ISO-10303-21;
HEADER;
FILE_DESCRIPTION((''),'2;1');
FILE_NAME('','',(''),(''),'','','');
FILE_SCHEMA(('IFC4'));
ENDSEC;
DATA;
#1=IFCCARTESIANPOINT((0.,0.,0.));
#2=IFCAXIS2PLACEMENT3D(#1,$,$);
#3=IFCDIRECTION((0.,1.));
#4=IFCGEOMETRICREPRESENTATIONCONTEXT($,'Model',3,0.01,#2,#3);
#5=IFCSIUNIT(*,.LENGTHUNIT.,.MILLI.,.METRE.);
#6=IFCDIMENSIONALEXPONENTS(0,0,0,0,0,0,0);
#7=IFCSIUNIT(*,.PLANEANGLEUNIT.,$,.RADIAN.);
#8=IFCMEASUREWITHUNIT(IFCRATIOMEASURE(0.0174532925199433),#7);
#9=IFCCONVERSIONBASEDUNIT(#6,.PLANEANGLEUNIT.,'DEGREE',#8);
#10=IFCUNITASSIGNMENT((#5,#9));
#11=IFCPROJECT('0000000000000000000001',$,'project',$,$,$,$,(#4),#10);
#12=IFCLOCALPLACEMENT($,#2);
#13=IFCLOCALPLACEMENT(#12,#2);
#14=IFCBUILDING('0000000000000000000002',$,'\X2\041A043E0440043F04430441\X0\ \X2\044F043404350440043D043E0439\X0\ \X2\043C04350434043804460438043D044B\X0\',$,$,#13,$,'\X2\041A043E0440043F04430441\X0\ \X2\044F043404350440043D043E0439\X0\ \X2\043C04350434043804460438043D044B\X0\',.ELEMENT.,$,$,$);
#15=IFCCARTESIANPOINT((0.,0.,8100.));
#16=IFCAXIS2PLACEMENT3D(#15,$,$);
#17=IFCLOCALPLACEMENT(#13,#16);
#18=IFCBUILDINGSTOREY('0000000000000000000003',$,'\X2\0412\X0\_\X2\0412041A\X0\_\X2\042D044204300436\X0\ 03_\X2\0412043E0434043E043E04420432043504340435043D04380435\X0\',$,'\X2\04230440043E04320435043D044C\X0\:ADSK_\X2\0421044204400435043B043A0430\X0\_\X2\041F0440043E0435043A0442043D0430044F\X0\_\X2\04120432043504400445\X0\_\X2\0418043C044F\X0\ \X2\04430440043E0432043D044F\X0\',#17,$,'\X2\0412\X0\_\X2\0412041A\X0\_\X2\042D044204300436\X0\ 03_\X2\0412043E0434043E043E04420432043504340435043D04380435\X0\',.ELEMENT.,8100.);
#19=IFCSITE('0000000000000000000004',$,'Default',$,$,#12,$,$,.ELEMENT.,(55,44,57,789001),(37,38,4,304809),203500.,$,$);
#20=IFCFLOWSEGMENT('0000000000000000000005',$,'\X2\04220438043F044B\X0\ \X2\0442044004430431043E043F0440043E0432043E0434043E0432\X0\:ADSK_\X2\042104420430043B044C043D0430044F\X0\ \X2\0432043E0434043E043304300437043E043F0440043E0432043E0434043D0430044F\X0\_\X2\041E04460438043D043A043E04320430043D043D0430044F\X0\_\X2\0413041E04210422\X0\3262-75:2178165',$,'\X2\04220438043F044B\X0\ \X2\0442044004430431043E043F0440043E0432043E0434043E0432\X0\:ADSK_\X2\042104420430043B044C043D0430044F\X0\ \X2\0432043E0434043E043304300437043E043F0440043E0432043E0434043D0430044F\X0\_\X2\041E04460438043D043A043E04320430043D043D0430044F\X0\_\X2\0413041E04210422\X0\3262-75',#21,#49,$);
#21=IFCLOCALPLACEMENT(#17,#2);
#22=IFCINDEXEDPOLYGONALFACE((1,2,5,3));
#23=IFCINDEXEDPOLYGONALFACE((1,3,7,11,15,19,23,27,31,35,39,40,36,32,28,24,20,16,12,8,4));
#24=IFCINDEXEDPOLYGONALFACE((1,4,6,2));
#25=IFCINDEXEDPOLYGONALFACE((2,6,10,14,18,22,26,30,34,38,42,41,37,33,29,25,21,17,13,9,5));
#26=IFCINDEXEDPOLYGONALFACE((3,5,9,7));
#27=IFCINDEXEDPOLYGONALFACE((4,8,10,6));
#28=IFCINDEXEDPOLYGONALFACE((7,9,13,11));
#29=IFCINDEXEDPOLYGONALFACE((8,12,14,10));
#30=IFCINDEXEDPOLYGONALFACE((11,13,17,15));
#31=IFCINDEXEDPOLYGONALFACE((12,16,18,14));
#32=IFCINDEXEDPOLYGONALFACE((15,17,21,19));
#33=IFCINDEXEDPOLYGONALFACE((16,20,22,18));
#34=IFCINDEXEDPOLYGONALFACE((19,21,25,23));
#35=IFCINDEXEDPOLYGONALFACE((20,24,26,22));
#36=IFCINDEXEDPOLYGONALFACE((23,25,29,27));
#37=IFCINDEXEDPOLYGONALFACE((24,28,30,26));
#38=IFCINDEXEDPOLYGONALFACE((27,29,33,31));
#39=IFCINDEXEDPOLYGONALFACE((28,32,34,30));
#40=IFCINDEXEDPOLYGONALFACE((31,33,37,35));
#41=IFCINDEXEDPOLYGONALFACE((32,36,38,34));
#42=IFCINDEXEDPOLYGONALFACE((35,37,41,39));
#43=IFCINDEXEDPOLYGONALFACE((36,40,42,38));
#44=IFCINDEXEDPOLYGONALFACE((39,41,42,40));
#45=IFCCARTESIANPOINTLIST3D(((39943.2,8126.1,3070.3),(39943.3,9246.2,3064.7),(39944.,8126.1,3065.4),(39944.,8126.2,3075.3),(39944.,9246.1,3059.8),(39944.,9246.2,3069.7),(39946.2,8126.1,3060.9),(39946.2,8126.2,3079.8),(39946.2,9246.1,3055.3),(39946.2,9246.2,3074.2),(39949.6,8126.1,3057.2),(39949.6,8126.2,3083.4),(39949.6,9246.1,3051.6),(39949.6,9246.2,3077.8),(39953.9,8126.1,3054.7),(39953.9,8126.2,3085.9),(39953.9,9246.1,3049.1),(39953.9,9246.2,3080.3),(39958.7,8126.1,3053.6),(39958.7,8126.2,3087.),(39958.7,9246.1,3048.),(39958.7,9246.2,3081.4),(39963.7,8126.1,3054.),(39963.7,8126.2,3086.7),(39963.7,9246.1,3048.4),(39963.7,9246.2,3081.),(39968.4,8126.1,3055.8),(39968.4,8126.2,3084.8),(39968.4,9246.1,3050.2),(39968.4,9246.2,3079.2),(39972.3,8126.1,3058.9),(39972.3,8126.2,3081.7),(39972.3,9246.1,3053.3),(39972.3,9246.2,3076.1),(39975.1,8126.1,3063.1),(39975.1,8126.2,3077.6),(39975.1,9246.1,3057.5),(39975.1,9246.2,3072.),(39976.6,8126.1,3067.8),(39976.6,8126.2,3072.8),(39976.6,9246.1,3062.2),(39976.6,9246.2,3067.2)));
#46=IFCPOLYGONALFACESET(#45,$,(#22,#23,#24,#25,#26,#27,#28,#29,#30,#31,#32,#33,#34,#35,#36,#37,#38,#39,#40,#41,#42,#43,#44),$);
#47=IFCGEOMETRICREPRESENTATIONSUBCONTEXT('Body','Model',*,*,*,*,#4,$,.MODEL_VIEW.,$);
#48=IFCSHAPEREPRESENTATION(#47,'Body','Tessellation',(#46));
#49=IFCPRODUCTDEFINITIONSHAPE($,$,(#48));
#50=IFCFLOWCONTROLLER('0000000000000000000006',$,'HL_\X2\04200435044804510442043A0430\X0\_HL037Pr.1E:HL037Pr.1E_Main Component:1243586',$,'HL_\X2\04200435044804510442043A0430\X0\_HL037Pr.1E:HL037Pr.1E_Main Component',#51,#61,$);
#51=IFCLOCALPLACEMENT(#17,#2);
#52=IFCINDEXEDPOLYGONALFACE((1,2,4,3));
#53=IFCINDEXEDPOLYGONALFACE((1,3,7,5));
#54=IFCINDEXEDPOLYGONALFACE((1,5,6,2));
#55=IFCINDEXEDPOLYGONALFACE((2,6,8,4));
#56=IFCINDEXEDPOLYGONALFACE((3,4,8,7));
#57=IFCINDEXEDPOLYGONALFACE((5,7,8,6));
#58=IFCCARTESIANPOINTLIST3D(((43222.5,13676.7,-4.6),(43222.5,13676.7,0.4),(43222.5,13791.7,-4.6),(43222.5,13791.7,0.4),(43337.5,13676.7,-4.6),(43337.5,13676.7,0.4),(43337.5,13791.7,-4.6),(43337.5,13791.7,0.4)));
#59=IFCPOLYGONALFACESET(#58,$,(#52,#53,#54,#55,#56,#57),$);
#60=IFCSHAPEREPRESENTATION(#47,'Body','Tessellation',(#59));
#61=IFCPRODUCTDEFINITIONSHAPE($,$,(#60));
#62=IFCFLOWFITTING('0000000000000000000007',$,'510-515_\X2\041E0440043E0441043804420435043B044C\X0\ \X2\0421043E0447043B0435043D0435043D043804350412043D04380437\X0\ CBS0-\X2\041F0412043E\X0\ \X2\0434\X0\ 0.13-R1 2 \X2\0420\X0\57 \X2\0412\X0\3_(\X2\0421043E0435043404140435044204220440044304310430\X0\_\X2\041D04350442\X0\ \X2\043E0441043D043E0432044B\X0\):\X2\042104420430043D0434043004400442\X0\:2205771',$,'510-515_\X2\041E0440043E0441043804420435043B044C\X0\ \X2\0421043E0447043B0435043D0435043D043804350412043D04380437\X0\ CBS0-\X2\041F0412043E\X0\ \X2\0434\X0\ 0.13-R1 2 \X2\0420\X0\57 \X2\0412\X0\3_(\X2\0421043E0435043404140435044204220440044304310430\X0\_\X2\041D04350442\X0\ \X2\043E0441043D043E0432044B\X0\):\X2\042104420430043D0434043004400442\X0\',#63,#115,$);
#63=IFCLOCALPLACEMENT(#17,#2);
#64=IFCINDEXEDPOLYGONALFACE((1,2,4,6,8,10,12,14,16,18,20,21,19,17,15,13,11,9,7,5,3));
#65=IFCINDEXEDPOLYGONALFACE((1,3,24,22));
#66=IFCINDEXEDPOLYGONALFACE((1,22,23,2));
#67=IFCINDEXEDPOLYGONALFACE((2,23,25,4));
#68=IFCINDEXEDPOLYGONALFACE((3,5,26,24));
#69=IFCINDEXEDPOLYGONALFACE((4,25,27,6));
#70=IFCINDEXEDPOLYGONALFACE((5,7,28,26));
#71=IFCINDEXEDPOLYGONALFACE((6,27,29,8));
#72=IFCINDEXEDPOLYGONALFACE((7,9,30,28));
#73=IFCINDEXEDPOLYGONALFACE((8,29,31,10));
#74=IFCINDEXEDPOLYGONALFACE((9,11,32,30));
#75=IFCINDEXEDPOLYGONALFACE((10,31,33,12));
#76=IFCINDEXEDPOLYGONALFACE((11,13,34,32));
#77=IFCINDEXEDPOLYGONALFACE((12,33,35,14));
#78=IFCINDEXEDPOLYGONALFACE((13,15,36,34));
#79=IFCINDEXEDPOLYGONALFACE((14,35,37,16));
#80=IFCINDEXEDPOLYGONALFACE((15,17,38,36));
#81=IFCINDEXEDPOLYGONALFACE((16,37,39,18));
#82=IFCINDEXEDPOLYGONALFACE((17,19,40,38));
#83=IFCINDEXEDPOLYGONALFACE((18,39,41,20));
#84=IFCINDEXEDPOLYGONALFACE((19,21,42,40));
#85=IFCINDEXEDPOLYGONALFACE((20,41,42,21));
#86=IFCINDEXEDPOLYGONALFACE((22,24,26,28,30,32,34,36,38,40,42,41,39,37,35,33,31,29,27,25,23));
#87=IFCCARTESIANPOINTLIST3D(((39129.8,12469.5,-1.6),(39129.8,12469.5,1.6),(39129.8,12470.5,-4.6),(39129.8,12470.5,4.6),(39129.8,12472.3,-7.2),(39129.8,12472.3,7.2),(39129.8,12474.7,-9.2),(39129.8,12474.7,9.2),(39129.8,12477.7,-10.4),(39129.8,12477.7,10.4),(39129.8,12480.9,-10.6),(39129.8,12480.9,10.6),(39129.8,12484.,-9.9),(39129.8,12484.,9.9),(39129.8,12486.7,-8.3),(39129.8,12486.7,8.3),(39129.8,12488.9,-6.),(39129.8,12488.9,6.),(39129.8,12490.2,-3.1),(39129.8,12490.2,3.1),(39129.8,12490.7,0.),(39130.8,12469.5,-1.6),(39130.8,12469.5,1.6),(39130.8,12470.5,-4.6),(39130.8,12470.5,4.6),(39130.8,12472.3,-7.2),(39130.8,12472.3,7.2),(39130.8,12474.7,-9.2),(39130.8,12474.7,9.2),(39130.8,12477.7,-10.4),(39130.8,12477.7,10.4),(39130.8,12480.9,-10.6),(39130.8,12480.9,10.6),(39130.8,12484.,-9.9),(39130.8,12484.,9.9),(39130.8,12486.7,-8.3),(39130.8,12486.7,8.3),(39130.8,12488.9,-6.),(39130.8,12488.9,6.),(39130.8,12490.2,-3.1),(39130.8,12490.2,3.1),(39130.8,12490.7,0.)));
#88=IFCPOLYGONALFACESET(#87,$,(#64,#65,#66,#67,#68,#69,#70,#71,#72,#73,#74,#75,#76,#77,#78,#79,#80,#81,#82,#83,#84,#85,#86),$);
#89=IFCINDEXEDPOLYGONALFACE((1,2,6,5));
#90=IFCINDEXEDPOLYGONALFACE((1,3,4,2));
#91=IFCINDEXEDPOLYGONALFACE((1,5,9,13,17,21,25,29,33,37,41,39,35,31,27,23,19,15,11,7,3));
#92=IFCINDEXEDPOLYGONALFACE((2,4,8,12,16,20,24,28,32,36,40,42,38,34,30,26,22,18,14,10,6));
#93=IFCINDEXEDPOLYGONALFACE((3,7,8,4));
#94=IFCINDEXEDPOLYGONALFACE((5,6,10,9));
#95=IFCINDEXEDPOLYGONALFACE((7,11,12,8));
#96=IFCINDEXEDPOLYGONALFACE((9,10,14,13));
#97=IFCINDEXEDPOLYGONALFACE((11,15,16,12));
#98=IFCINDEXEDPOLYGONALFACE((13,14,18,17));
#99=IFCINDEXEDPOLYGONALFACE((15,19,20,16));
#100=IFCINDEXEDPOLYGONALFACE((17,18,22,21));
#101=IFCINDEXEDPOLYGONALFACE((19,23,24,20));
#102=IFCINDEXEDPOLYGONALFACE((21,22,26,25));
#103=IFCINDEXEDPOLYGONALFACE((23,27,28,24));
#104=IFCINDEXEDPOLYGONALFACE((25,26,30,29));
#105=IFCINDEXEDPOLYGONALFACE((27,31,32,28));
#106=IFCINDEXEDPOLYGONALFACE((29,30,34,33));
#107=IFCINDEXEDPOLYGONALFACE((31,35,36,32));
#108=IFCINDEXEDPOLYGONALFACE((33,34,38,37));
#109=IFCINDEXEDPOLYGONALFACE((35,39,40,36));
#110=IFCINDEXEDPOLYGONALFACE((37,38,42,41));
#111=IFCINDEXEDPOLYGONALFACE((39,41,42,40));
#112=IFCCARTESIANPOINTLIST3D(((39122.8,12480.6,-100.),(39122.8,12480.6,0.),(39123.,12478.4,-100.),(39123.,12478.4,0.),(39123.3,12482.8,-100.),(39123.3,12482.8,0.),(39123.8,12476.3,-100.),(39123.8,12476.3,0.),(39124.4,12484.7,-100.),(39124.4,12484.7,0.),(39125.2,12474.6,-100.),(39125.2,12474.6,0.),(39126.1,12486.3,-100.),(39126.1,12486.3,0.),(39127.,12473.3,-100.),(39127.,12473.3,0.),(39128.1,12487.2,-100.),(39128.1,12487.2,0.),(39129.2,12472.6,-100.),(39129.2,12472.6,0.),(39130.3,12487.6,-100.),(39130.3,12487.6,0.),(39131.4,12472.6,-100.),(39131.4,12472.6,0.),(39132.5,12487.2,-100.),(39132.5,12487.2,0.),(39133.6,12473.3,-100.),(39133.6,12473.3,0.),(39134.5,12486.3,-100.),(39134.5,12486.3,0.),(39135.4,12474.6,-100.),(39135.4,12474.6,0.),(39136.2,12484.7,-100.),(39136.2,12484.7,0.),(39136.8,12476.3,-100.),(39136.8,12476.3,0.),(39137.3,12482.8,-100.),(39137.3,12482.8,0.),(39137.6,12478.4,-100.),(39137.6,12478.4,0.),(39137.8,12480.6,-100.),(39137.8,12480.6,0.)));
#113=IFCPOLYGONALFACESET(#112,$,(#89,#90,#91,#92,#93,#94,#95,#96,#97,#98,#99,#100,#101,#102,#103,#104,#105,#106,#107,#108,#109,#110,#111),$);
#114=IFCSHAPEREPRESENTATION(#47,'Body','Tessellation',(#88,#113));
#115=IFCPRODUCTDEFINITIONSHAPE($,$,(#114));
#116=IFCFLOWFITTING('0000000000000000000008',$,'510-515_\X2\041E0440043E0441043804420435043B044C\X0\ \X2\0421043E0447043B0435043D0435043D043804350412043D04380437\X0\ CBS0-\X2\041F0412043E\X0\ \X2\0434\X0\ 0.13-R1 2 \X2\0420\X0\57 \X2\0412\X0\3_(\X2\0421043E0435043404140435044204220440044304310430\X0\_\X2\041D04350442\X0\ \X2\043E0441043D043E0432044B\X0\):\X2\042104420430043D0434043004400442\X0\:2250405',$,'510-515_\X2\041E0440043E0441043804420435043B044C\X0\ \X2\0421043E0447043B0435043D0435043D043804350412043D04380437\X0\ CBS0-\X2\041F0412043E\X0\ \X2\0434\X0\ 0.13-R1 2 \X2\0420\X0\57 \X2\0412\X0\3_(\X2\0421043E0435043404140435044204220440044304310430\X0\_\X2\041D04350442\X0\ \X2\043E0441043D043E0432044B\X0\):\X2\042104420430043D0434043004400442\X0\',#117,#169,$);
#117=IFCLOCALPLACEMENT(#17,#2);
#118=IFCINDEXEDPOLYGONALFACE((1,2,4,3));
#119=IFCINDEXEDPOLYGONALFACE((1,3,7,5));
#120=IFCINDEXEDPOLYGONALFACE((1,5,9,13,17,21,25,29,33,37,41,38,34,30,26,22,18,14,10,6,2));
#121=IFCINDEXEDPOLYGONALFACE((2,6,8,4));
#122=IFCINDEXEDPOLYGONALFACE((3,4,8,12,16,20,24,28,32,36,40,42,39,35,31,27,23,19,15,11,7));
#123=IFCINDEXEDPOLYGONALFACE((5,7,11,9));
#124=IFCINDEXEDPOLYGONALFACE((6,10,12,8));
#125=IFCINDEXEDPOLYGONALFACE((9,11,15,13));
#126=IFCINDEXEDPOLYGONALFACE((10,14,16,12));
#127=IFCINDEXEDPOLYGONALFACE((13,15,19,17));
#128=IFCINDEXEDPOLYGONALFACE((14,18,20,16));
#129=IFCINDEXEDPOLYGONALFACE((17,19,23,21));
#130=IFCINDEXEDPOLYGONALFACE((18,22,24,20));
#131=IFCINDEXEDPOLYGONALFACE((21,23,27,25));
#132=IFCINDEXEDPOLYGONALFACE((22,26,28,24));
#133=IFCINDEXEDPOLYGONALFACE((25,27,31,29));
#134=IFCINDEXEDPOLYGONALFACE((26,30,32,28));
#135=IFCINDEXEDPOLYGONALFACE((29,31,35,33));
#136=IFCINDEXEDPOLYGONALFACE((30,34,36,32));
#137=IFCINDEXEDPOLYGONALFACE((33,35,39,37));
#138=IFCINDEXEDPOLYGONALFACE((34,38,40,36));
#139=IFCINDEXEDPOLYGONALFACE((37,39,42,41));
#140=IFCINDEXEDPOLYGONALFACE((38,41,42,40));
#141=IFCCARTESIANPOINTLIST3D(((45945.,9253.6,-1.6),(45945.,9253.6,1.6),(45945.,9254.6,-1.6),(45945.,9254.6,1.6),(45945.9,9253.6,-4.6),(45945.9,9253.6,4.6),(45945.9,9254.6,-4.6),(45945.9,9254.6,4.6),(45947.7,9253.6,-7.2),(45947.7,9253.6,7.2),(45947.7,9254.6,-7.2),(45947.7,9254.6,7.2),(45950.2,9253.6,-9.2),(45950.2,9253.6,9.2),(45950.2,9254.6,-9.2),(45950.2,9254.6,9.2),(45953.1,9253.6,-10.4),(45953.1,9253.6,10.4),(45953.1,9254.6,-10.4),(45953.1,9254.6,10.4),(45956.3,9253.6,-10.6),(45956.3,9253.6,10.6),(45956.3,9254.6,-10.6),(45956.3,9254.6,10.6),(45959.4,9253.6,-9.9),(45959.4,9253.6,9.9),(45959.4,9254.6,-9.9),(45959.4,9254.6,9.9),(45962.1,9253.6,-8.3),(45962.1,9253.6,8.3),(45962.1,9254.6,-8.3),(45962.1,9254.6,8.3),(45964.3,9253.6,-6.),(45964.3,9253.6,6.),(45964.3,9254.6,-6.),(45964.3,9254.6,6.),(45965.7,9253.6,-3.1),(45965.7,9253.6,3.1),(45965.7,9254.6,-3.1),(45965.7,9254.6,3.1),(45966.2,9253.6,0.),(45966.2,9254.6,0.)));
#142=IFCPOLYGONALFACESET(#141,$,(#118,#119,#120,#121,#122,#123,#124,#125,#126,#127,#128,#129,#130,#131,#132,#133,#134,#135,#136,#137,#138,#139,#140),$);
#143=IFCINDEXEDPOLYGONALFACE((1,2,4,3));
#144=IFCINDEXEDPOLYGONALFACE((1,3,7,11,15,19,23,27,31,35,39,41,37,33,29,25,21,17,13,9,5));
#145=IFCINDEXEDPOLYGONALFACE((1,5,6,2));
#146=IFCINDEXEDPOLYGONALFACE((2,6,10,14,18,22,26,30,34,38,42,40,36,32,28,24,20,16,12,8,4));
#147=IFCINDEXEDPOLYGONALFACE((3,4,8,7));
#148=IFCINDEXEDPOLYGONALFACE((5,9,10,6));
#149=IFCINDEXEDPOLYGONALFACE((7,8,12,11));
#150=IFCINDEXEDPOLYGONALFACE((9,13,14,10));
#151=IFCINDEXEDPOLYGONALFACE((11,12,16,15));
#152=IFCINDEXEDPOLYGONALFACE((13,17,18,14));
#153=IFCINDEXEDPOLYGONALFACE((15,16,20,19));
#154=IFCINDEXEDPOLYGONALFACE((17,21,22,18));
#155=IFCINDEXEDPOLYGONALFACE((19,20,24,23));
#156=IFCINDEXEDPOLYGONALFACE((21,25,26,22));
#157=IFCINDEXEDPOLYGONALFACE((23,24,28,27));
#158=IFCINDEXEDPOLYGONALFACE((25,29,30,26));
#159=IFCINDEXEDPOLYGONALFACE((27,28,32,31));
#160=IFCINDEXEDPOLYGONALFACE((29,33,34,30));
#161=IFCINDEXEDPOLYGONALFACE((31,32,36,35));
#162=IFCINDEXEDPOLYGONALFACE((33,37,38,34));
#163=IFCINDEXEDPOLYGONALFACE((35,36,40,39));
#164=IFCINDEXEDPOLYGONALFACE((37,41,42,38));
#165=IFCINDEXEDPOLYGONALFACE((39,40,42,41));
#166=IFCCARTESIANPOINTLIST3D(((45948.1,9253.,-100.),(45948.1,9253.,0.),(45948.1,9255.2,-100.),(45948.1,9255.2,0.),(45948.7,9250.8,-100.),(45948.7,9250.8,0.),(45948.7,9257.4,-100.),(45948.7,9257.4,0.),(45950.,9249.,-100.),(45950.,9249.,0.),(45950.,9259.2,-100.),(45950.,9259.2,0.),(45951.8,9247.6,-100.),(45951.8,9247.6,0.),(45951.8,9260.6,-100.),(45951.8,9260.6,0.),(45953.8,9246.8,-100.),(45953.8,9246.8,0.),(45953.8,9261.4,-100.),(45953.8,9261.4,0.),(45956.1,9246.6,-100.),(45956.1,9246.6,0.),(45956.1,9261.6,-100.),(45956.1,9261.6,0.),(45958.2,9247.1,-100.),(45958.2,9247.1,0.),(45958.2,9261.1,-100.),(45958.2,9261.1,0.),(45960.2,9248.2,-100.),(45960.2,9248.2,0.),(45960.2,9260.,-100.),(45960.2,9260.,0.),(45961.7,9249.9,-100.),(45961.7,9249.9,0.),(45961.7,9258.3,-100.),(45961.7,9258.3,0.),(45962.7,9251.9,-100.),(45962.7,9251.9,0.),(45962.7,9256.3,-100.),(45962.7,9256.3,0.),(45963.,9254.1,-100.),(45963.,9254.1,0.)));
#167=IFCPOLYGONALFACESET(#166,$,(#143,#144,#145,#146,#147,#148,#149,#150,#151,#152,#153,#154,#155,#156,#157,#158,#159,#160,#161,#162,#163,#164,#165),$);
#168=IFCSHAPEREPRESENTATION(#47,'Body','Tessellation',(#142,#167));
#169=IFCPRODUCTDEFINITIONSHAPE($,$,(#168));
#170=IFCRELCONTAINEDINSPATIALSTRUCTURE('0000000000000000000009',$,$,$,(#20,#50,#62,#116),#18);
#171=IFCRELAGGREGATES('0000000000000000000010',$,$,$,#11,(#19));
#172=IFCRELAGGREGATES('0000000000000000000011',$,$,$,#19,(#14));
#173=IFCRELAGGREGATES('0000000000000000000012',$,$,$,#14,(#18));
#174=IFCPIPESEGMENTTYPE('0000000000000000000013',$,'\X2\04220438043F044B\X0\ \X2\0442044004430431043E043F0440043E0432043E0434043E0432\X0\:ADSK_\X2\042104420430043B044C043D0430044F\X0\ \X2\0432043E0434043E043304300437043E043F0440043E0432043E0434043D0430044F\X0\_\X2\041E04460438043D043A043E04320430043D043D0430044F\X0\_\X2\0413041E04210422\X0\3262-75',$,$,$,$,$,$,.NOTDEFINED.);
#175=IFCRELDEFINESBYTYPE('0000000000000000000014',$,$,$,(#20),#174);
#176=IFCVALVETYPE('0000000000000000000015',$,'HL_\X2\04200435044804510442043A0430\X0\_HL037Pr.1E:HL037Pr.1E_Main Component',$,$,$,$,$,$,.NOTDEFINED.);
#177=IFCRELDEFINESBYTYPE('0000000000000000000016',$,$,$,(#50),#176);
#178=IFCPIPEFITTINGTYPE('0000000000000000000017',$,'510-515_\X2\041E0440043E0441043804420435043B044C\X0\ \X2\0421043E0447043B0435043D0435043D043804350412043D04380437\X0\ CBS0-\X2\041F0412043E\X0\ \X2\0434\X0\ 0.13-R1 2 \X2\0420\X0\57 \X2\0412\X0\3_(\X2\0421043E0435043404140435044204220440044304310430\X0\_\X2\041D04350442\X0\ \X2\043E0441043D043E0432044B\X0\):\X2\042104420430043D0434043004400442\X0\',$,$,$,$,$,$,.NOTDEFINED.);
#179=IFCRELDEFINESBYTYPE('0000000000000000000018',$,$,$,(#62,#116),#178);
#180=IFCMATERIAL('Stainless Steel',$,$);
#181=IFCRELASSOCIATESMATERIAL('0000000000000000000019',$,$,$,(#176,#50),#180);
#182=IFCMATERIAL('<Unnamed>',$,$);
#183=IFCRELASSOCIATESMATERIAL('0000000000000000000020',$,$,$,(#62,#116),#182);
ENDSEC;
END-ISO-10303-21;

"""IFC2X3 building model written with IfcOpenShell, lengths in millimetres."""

from ifc_helpers import new_model, entity, si_unit, converted_unit, direction, frame, origin, origin_2d_with_axis, place, context, subcontext, project, spatial, rectangle, circle, extrude, source, transform, mapped, material, type_object, type_shapes, element, save


model = new_model("IFC2X3")

# Units and contexts
model_context = context("Model", 3, precision=0.01, world=origin(), true_north=direction((0.0, 1.0)))
body_context = subcontext(model_context, "Body", "Model", "MODEL_VIEW")
ifc_project = project(units=[si_unit("LENGTHUNIT", "METRE", prefix="MILLI"), converted_unit("PLANEANGLEUNIT", "DEGREE", entity("IfcRatioMeasure", 0.0174532925199433), si_unit("PLANEANGLEUNIT", "RADIAN"), dimensions=[0, 0, 0, 0, 0, 0, 0])], contexts=[model_context])

# Site, building, storey
site_placement = place(None, origin())
site = spatial("IfcSite", under=ifc_project, at=site_placement, Name="Default", CompositionType="ELEMENT", RefLatitude=(55, 44, 57, 789001), RefLongitude=(37, 38, 4, 304809), RefElevation=203500.0)
building_placement = place(site_placement, origin())
building = spatial("IfcBuilding", under=site, at=building_placement, Name="Корпус ядерной медицины", LongName="Корпус ядерной медицины", CompositionType="ELEMENT")
storey_placement = place(building_placement, frame((0.0, 0.0, 8100.0)))
storey = spatial("IfcBuildingStorey", under=building, at=storey_placement, Name="В_ВК_Этаж 03_Водоотведение", ObjectType="Уровень:ADSK_Стрелка_Проектная_Вверх_Имя уровня", LongName="В_ВК_Этаж 03_Водоотведение", CompositionType="ELEMENT", Elevation=8100.0)

# Flow segment
pipe_segment_type_1 = type_object("IfcPipeSegmentType", Name="Типы трубопроводов:ADSK_Стальная водогазопроводная_Оцинкованная_ГОСТ3262-75", PredefinedType="NOTDEFINED")
for number, where, name in (
    (1, (39941.7, 8126.1, 3046.4), "Типы трубопроводов:ADSK_Стальная водогазопроводная_Оцинкованная_ГОСТ3262-75:2178165"),
):
    element("IfcFlowSegment", number, at=place(storey_placement, frame(where)), inside=storey, type_object=pipe_segment_type_1, Name=name, ObjectType="Типы трубопроводов:ADSK_Стальная водогазопроводная_Оцинкованная_ГОСТ3262-75", context=body_context, shape_type="SweptSolid", body=[
        extrude(circle(Radius=16.8, at=origin_2d_with_axis()), frame((18.4, 1120.1, 18.4), z_axis=(-0.000001, -0.999987, 0.005), x_axis=(-1.0, 0.000001, 0.0)), (0.0, 0.0, 1.0), 1120.0),
    ])

# Flow controller
ifc_material_1 = material(Name="Stainless Steel")
valve_type = type_object("IfcValveType", Name="HL_Решётка_HL037Pr.1E:HL037Pr.1E_Main Component", PredefinedType="NOTDEFINED", material=ifc_material_1)
shared_shape_1 = source(origin(), body_context, "Body", "SweptSolid", [
    extrude(rectangle(XDim=115.0, YDim=115.0, at=origin_2d_with_axis()), frame((0.0, 0.0, -5.0), z_axis=(0.0, 0.0, 1.0), x_axis=(0.0, -1.0, 0.0)), (0.0, 0.0, 1.0), 5.0),
])
type_shapes(valve_type, [shared_shape_1])
flow_controller_placement = place(storey_placement, frame((43280.0, 13734.2, 0.4)))
element("IfcFlowController", 2, at=flow_controller_placement, inside=storey, type_object=valve_type, material=ifc_material_1, Name="HL_Решётка_HL037Pr.1E:HL037Pr.1E_Main Component:1243586", ObjectType="HL_Решётка_HL037Pr.1E:HL037Pr.1E_Main Component", context=body_context, shape_type="MappedRepresentation", body=[
    mapped(shared_shape_1, transform((0.0, 0.0, 0.0), scale=1.0)),
])

# Flow fittings
ifc_material_2 = material(Name="<Unnamed>")
pipe_fitting_type = type_object("IfcPipeFittingType", Name="510-515_Ороситель СочленениеВниз CBS0-ПВо д 0.13-R1 2 Р57 В3_(СоедДетТруба_Нет основы):Стандарт", PredefinedType="NOTDEFINED")
shared_shape_2 = source(origin(), body_context, "Body", "SweptSolid", [
    extrude(circle(Radius=10.7, at=origin_2d_with_axis()), frame((-0.5, 0.0, 0.0), z_axis=(1.0, 0.0, 0.0), x_axis=(0.0, 1.0, 0.0)), (0.0, 0.0, 1.0), 1.0),
    extrude(circle(Radius=7.5, at=origin_2d_with_axis()), frame((0.0, 0.0, -100.0), z_axis=(0.0, 0.0, 1.0), x_axis=(0.0, 1.0, 0.0)), (0.0, 0.0, 1.0), 100.0),
])
type_shapes(pipe_fitting_type, [shared_shape_2])
flow_fitting_placement = place(storey_placement, frame((39130.3, 12480.1, 0.0)))
element("IfcFlowFitting", 3, at=flow_fitting_placement, inside=storey, type_object=pipe_fitting_type, material=ifc_material_2, Name="510-515_Ороситель СочленениеВниз CBS0-ПВо д 0.13-R1 2 Р57 В3_(СоедДетТруба_Нет основы):Стандарт:2205771", ObjectType="510-515_Ороситель СочленениеВниз CBS0-ПВо д 0.13-R1 2 Р57 В3_(СоедДетТруба_Нет основы):Стандарт", context=body_context, shape_type="MappedRepresentation", body=[
    mapped(shared_shape_2, transform((0.0, 0.0, 0.0), scale=1.0)),
])
for number, where, z_axis, x_axis, name in (
    (4, (45955.5, 9254.1, 0.0), (0.0, 0.0, 1.0), (0.0, -1.0, 0.0), "510-515_Ороситель СочленениеВниз CBS0-ПВо д 0.13-R1 2 Р57 В3_(СоедДетТруба_Нет основы):Стандарт:2250405"),
):
    element("IfcFlowFitting", number, at=place(storey_placement, frame(where, z_axis=z_axis, x_axis=x_axis)), inside=storey, type_object=pipe_fitting_type, material=ifc_material_2, Name=name, ObjectType="510-515_Ороситель СочленениеВниз CBS0-ПВо д 0.13-R1 2 Р57 В3_(СоедДетТруба_Нет основы):Стандарт", context=body_context, shape_type="MappedRepresentation", body=[
        mapped(shared_shape_2, transform((0.0, 0.0, 0.0), scale=1.0)),
    ])

save(model, "model.ifc")
